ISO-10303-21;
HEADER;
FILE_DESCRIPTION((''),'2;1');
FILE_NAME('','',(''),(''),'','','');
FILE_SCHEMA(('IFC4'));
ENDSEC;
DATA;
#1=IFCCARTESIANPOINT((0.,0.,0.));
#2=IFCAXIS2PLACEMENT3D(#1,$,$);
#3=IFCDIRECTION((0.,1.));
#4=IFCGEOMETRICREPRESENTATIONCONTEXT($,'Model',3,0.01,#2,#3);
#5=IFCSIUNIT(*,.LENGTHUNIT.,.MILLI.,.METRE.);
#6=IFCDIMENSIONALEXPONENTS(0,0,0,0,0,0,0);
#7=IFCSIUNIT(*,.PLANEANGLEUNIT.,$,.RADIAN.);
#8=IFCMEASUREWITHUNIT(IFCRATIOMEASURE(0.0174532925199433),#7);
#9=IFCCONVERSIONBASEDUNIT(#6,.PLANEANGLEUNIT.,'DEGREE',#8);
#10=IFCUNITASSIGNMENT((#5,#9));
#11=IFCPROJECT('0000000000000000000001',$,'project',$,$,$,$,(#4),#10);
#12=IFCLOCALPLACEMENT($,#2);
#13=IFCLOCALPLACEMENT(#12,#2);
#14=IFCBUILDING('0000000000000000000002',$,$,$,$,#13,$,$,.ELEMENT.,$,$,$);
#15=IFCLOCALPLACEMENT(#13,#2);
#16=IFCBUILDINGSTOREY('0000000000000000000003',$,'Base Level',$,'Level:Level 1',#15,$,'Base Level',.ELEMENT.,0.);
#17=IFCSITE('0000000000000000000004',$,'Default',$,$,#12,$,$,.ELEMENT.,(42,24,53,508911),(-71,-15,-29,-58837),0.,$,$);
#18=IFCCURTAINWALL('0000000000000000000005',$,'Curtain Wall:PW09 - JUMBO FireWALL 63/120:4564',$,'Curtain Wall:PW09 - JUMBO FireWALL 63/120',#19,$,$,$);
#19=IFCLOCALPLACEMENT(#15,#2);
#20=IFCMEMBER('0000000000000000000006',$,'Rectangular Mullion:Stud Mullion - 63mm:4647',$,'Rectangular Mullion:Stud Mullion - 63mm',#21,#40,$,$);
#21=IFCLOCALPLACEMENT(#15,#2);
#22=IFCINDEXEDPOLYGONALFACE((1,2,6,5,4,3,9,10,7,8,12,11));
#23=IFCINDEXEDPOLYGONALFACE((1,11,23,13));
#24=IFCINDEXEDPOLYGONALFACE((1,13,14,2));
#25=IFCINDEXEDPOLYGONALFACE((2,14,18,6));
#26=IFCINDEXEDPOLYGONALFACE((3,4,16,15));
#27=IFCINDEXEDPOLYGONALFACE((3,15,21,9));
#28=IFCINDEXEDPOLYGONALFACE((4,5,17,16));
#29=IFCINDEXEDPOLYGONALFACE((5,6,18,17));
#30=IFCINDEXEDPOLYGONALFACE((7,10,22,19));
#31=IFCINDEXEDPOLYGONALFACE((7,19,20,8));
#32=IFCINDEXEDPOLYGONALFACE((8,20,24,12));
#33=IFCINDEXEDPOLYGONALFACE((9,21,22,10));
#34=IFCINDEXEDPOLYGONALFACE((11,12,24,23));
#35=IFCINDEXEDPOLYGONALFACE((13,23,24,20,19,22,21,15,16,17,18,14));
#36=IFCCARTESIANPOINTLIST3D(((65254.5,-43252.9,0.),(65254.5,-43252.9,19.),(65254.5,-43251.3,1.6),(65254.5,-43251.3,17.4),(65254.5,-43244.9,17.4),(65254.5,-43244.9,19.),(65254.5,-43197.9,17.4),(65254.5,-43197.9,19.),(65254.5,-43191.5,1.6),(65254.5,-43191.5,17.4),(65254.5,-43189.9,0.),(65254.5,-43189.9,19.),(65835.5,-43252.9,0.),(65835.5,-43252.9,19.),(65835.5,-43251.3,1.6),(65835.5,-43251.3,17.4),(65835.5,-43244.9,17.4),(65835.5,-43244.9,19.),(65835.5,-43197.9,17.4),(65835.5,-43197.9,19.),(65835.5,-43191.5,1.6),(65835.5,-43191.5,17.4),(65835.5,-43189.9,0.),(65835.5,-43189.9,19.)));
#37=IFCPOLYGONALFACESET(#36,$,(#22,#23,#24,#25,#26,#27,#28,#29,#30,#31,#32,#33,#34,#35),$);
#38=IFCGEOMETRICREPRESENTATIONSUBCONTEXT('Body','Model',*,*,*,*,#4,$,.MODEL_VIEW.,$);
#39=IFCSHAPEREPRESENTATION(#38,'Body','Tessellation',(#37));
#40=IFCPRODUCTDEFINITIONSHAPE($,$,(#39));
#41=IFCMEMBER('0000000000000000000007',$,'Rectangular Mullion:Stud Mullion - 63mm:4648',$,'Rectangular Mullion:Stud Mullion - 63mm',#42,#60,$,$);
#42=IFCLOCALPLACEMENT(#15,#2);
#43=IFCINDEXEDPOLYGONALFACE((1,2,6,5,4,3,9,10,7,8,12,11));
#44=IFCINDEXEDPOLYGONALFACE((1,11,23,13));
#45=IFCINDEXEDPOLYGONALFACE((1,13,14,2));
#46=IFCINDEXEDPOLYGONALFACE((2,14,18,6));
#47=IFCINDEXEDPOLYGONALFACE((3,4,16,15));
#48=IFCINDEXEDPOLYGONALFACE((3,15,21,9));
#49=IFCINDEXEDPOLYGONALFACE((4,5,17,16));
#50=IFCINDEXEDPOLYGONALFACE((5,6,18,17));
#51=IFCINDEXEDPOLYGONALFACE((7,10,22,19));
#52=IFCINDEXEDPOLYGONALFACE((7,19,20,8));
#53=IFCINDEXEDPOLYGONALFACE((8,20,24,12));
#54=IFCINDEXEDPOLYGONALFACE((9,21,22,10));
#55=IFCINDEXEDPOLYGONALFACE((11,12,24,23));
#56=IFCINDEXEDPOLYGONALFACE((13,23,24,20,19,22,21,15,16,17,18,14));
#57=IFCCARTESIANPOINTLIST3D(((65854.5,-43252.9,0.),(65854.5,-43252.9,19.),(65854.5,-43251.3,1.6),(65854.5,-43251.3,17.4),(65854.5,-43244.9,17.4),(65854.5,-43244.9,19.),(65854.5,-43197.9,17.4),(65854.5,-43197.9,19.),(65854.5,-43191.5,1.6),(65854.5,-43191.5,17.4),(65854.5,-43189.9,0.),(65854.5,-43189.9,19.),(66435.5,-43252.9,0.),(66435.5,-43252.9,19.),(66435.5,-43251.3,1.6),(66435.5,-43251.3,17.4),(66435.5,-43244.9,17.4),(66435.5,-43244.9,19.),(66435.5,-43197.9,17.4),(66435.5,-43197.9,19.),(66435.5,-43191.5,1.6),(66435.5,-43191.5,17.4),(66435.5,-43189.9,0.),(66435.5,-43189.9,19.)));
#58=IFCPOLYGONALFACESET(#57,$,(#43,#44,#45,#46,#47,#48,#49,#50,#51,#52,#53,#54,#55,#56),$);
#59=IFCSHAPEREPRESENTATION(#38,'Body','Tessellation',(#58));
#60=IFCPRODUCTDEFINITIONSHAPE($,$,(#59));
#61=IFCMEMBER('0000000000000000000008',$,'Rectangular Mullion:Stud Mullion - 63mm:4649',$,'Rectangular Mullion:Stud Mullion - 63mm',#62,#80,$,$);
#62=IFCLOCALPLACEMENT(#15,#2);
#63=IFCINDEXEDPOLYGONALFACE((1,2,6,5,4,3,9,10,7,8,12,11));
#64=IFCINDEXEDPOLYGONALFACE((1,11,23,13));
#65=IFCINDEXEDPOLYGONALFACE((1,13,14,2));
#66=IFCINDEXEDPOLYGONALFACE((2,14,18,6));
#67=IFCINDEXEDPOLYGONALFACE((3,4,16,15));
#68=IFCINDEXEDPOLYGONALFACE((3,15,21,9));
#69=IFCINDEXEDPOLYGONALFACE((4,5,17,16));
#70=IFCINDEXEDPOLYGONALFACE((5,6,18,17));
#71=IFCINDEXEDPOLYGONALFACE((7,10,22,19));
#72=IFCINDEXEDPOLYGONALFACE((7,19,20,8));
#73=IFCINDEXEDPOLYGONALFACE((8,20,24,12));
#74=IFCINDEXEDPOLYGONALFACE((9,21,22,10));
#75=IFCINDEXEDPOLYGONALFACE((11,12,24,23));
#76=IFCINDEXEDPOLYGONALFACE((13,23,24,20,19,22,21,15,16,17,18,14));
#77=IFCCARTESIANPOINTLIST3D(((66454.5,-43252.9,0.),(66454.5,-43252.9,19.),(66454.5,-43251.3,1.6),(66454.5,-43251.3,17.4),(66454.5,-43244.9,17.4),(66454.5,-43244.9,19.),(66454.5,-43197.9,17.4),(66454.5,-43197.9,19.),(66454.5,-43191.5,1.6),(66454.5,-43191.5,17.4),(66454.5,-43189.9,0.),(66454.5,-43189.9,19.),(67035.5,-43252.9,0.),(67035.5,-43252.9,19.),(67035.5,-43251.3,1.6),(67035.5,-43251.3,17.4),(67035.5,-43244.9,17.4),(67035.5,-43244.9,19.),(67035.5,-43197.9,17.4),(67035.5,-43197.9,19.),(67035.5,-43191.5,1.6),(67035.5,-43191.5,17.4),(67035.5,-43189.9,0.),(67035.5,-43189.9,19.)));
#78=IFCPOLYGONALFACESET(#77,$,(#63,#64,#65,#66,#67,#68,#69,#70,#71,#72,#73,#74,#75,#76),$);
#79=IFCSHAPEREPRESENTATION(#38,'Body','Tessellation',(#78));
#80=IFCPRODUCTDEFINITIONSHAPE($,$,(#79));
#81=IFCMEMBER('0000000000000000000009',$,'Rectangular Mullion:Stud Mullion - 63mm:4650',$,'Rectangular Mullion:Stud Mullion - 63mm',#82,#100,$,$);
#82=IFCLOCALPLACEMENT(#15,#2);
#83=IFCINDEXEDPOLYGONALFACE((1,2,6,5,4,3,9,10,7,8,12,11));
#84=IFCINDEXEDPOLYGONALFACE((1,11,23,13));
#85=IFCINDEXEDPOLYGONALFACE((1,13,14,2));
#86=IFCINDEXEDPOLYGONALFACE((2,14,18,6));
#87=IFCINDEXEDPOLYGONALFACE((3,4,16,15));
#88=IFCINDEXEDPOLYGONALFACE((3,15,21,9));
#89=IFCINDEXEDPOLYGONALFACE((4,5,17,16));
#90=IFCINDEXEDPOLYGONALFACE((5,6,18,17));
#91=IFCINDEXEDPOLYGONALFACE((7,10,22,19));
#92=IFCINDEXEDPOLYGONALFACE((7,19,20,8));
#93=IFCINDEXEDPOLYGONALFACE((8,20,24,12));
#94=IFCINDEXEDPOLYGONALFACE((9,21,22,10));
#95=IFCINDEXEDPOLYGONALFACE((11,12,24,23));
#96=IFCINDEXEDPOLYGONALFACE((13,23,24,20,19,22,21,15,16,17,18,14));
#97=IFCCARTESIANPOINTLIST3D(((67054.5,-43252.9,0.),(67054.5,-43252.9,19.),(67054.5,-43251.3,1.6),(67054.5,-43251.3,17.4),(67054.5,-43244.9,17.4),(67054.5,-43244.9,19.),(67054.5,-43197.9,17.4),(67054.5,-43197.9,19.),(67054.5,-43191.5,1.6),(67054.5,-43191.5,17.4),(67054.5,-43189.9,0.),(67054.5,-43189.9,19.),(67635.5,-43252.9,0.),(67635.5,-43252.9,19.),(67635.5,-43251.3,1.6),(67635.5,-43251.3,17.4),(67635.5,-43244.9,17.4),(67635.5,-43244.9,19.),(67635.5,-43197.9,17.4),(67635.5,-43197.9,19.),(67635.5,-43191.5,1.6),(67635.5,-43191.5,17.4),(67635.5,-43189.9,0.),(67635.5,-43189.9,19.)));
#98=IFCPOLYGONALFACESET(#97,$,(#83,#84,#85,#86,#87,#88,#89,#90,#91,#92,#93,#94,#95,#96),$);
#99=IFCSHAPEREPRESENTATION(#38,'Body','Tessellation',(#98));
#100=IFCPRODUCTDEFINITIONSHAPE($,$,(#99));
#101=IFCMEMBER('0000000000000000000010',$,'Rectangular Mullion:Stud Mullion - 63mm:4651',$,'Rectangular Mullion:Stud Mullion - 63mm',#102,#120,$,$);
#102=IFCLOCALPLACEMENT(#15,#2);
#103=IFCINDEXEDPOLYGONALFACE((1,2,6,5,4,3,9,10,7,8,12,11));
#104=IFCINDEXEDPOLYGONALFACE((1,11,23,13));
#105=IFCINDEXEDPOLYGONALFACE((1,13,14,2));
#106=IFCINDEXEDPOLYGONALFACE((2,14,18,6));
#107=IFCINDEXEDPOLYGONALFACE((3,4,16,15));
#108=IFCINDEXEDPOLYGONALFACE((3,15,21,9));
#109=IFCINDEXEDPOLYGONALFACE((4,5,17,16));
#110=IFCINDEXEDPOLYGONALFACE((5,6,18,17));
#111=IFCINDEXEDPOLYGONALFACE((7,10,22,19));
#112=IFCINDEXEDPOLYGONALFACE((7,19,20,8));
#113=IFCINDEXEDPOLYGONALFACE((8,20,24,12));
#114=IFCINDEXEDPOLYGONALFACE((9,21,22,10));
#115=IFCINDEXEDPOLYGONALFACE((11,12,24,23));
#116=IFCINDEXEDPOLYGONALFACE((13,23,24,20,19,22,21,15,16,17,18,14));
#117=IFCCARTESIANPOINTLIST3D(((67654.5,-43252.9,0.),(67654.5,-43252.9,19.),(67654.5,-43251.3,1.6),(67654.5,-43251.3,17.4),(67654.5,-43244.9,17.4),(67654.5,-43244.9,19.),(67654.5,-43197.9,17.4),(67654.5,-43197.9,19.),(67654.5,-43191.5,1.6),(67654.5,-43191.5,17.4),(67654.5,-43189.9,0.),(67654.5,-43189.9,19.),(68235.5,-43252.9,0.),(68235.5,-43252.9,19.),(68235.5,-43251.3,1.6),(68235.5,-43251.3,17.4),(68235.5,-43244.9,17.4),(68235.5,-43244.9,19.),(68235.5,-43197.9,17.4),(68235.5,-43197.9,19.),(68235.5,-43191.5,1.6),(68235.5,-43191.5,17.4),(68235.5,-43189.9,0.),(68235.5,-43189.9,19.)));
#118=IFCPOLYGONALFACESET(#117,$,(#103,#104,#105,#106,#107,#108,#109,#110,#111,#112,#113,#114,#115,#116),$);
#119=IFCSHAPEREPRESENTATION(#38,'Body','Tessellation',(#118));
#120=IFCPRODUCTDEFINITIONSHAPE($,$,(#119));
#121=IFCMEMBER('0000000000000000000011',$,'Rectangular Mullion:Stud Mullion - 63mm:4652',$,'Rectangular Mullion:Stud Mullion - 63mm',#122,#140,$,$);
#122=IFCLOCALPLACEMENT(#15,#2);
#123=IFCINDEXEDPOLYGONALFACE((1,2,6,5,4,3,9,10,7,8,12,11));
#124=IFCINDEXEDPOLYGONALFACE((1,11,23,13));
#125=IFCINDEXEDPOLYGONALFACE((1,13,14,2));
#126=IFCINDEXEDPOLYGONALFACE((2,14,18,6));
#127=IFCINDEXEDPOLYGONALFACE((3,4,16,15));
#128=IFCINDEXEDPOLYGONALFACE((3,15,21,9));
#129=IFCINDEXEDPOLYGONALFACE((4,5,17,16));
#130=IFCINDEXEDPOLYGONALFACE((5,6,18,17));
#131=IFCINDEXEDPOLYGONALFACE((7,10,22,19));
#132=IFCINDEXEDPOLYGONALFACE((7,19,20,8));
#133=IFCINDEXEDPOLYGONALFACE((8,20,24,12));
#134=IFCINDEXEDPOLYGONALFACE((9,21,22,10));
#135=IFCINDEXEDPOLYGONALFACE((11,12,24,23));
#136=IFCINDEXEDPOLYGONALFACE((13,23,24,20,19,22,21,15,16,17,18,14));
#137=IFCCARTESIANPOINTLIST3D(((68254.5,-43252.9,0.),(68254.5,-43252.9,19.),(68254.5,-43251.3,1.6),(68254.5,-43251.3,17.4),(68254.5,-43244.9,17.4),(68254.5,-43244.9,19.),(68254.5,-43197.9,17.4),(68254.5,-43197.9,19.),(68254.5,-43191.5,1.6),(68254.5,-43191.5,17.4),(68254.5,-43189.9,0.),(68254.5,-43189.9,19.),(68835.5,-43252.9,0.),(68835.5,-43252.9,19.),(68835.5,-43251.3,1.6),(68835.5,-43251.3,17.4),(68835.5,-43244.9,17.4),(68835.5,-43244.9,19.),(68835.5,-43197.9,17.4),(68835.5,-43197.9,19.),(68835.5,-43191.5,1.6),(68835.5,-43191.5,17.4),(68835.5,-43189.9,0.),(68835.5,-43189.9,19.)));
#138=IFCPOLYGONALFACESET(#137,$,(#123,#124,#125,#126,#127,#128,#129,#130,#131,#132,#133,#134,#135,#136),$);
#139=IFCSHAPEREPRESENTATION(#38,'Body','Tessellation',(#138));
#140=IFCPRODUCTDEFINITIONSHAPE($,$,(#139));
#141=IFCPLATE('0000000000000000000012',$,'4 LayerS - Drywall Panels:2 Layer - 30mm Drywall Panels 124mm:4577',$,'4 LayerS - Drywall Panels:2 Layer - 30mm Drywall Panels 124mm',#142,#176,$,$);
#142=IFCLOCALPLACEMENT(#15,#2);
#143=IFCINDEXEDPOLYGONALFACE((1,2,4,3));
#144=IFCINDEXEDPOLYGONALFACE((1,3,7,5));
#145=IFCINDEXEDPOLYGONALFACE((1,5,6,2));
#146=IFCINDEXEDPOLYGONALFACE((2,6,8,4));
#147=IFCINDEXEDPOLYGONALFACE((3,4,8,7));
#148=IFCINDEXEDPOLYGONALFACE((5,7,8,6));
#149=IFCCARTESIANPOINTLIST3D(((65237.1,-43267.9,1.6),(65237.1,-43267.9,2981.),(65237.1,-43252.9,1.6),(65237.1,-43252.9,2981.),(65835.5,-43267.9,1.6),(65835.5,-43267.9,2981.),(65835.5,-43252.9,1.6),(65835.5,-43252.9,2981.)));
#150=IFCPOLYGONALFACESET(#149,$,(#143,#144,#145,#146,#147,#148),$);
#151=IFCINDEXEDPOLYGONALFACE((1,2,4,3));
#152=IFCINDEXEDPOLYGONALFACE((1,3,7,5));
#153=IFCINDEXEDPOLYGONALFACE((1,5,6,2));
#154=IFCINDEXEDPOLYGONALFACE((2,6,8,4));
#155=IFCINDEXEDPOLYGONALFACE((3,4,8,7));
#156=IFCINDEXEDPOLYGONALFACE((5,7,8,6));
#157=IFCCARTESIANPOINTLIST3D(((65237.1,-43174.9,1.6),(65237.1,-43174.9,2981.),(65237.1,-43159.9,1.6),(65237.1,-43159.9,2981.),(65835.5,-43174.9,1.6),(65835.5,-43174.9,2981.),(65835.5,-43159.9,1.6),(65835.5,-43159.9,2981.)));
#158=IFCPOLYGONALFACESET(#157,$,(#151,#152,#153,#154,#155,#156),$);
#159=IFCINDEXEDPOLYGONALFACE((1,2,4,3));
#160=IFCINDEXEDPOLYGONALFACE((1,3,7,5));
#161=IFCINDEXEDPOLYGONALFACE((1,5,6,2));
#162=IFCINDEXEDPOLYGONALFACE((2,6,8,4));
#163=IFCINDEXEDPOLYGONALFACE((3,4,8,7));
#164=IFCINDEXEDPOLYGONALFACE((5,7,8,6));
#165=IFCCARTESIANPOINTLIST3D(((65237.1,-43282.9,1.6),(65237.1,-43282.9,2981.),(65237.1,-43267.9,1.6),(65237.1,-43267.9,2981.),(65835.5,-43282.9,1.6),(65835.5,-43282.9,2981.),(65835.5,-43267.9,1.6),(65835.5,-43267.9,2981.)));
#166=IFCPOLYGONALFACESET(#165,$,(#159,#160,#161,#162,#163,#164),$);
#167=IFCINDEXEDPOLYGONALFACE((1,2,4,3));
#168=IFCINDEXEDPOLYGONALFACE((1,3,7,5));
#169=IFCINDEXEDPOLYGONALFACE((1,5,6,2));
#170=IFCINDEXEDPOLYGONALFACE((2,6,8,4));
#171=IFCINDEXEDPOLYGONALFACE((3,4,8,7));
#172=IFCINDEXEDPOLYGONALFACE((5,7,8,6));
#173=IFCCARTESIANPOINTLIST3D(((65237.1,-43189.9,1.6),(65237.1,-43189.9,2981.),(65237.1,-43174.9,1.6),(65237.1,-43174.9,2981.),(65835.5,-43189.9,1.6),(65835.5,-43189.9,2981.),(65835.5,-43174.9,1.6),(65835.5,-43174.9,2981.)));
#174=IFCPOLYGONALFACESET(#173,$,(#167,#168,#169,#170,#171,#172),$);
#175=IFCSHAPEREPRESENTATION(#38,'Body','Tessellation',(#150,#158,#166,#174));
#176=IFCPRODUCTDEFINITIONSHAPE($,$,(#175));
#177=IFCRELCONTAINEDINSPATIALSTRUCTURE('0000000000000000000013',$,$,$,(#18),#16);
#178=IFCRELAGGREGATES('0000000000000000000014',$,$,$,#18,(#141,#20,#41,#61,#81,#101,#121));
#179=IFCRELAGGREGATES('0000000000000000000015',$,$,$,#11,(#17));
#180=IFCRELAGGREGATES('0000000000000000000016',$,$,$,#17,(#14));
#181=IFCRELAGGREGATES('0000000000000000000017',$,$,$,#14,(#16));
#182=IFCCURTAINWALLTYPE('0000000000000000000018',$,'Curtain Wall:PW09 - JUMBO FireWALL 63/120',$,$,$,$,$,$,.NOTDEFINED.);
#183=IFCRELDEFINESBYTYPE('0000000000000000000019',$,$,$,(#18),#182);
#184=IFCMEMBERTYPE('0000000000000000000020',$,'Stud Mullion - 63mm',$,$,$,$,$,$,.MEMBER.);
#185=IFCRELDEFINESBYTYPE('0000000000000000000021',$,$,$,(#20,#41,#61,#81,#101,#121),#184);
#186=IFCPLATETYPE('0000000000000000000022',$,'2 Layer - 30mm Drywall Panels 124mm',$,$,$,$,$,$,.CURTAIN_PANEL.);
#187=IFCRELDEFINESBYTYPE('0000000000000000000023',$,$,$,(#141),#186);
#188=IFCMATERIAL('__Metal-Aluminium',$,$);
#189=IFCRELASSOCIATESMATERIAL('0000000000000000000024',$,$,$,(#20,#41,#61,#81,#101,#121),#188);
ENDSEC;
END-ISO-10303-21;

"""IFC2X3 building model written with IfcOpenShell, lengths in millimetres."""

from ifc_helpers import new_model, entity, si_unit, converted_unit, direction, frame, frame_2d, origin, origin_2d_with_axis, place, context, subcontext, project, spatial, polyline, rectangle, outline, extrude, source, transform, mapped, material, type_object, type_shapes, element, aggregate, save


model = new_model("IFC2X3")

# Units and contexts
model_context = context("Model", 3, precision=0.01, world=origin(), true_north=direction((0.0, 1.0)))
body_context = subcontext(model_context, "Body", "Model", "MODEL_VIEW")
ifc_project = project(units=[si_unit("LENGTHUNIT", "METRE", prefix="MILLI"), converted_unit("PLANEANGLEUNIT", "DEGREE", entity("IfcRatioMeasure", 0.0174532925199433), si_unit("PLANEANGLEUNIT", "RADIAN"), dimensions=[0, 0, 0, 0, 0, 0, 0])], contexts=[model_context])

# Site, building, storey
site_placement = place(None, origin())
site = spatial("IfcSite", under=ifc_project, at=site_placement, Name="Default", CompositionType="ELEMENT", RefLatitude=(42, 24, 53, 508911), RefLongitude=(-71, -15, -29, -58837), RefElevation=0.0)
building_placement = place(site_placement, origin())
building = spatial("IfcBuilding", under=site, at=building_placement, CompositionType="ELEMENT")
storey_placement = place(building_placement, origin())
storey = spatial("IfcBuildingStorey", under=building, at=storey_placement, Name="Base Level", ObjectType="Level:Level 1", LongName="Base Level", CompositionType="ELEMENT", Elevation=0.0)

# Curtain wall, members, plate
curtain_wall_type = type_object("IfcCurtainWallType", Name="Curtain Wall:PW09 - JUMBO FireWALL 63/120", PredefinedType="NOTDEFINED")
curtain_wall_placement = place(building_placement, origin())
curtain_wall = element("IfcCurtainWall", 1, at=curtain_wall_placement, inside=storey, type_object=curtain_wall_type, Name="Curtain Wall:PW09 - JUMBO FireWALL 63/120:4564", ObjectType="Curtain Wall:PW09 - JUMBO FireWALL 63/120")
ifc_material = material(Name="__Metal-Aluminium")
member_type_1 = type_object("IfcMemberType", Name="Stud Mullion - 63mm", PredefinedType="MEMBER")
shared_shape_1 = source(origin(), body_context, "Body", "SweptSolid", [
    extrude(outline(polyline([(23.5, -6.6), (31.5, -6.6), (31.5, 12.4), (-31.5, 12.4), (-31.5, -6.6), (-23.5, -6.6), (-23.5, -5.0), (-29.9, -5.0), (-29.9, 10.8), (29.9, 10.8), (29.9, -5.0), (23.5, -5.0), (23.5, -6.6)])), frame((-12.4, 0.0, -581.0), z_axis=(0.0, 0.0, 1.0), x_axis=(0.0, -1.0, 0.0)), (0.0, 0.0, 1.0), 581.0),
])
type_shapes(member_type_1, [shared_shape_1])
member_1_placement = place(building_placement, frame((65254.5, -43221.4, 0.0), z_axis=(-1.0, 0.0, 0.0), x_axis=(0.0, 0.0, -1.0)))
member_1 = element("IfcMember", 2, at=member_1_placement, type_object=member_type_1, material=ifc_material, Name="Rectangular Mullion:Stud Mullion - 63mm:4647", ObjectType="Rectangular Mullion:Stud Mullion - 63mm", context=body_context, shape_type="MappedRepresentation", body=[
    mapped(shared_shape_1, transform((0.0, 0.0, 0.0), scale=1.0)),
])
member_2_placement = place(building_placement, frame((65854.5, -43221.4, 0.0), z_axis=(-1.0, 0.0, 0.0), x_axis=(0.0, 0.0, -1.0)))
member_2 = element("IfcMember", 3, at=member_2_placement, type_object=member_type_1, material=ifc_material, Name="Rectangular Mullion:Stud Mullion - 63mm:4648", ObjectType="Rectangular Mullion:Stud Mullion - 63mm", context=body_context, shape_type="MappedRepresentation", body=[
    mapped(shared_shape_1, transform((0.0, 0.0, 0.0), scale=1.0)),
])
member_3_placement = place(building_placement, frame((66454.5, -43221.4, 0.0), z_axis=(-1.0, 0.0, 0.0), x_axis=(0.0, 0.0, -1.0)))
member_3 = element("IfcMember", 4, at=member_3_placement, type_object=member_type_1, material=ifc_material, Name="Rectangular Mullion:Stud Mullion - 63mm:4649", ObjectType="Rectangular Mullion:Stud Mullion - 63mm", context=body_context, shape_type="MappedRepresentation", body=[
    mapped(shared_shape_1, transform((0.0, 0.0, 0.0), scale=1.0)),
])
member_4_placement = place(building_placement, frame((67054.5, -43221.4, 0.0), z_axis=(-1.0, 0.0, 0.0), x_axis=(0.0, 0.0, -1.0)))
member_4 = element("IfcMember", 5, at=member_4_placement, type_object=member_type_1, material=ifc_material, Name="Rectangular Mullion:Stud Mullion - 63mm:4650", ObjectType="Rectangular Mullion:Stud Mullion - 63mm", context=body_context, shape_type="MappedRepresentation", body=[
    mapped(shared_shape_1, transform((0.0, 0.0, 0.0), scale=1.0)),
])
member_5_placement = place(building_placement, frame((67654.5, -43221.4, 0.0), z_axis=(-1.0, 0.0, 0.0), x_axis=(0.0, 0.0, -1.0)))
member_5 = element("IfcMember", 6, at=member_5_placement, type_object=member_type_1, material=ifc_material, Name="Rectangular Mullion:Stud Mullion - 63mm:4651", ObjectType="Rectangular Mullion:Stud Mullion - 63mm", context=body_context, shape_type="MappedRepresentation", body=[
    mapped(shared_shape_1, transform((0.0, 0.0, 0.0), scale=1.0)),
])
member_6_placement = place(building_placement, frame((68254.5, -43221.4, 0.0), z_axis=(-1.0, 0.0, 0.0), x_axis=(0.0, 0.0, -1.0)))
member_6 = element("IfcMember", 7, at=member_6_placement, type_object=member_type_1, material=ifc_material, Name="Rectangular Mullion:Stud Mullion - 63mm:4652", ObjectType="Rectangular Mullion:Stud Mullion - 63mm", context=body_context, shape_type="MappedRepresentation", body=[
    mapped(shared_shape_1, transform((0.0, 0.0, 0.0), scale=1.0)),
])
plate_type = type_object("IfcPlateType", Name="2 Layer - 30mm Drywall Panels 124mm", PredefinedType="CURTAIN_PANEL")
shared_shape_2 = source(origin(), body_context, "Body", "SweptSolid", [
    extrude(rectangle(XDim=15.0, YDim=598.4, at=origin_2d_with_axis()), frame((0.0, -39.0, 0.0), z_axis=(0.0, 0.0, 1.0), x_axis=(0.0, 1.0, 0.0)), (0.0, 0.0, 1.0), 2979.4),
    extrude(rectangle(XDim=15.0, YDim=598.4, at=origin_2d_with_axis()), frame((0.0, 54.0, 0.0), z_axis=(0.0, 0.0, 1.0), x_axis=(0.0, 1.0, 0.0)), (0.0, 0.0, 1.0), 2979.4),
    extrude(rectangle(XDim=598.4, YDim=15.0, at=frame_2d((0.0, 0.0), x_axis=(1.0, 0.0))), frame((0.0, -54.0, 0.0), z_axis=(0.0, 0.0, 1.0), x_axis=(-1.0, 0.0, 0.0)), (0.0, 0.0, 1.0), 2979.4),
    extrude(rectangle(XDim=15.0, YDim=598.4, at=frame_2d((0.0, 0.0), x_axis=(1.0, 0.0))), frame((0.0, 39.0, 0.0), z_axis=(0.0, 0.0, 1.0), x_axis=(0.0, 1.0, 0.0)), (0.0, 0.0, 1.0), 2979.4),
])
type_shapes(plate_type, [shared_shape_2])
plate_1_placement = place(curtain_wall_placement, frame((65536.3, -43221.4, 1.6)))
plate_1 = element("IfcPlate", 8, at=plate_1_placement, type_object=plate_type, Name="4 LayerS - Drywall Panels:2 Layer - 30mm Drywall Panels 124mm:4577", ObjectType="4 LayerS - Drywall Panels:2 Layer - 30mm Drywall Panels 124mm", context=body_context, shape_type="MappedRepresentation", body=[
    mapped(shared_shape_2, transform((0.0, 0.0, 0.0), scale=1.0)),
])
aggregate(curtain_wall, [plate_1, member_1, member_2, member_3, member_4, member_5, member_6])

save(model, "model.ifc")
